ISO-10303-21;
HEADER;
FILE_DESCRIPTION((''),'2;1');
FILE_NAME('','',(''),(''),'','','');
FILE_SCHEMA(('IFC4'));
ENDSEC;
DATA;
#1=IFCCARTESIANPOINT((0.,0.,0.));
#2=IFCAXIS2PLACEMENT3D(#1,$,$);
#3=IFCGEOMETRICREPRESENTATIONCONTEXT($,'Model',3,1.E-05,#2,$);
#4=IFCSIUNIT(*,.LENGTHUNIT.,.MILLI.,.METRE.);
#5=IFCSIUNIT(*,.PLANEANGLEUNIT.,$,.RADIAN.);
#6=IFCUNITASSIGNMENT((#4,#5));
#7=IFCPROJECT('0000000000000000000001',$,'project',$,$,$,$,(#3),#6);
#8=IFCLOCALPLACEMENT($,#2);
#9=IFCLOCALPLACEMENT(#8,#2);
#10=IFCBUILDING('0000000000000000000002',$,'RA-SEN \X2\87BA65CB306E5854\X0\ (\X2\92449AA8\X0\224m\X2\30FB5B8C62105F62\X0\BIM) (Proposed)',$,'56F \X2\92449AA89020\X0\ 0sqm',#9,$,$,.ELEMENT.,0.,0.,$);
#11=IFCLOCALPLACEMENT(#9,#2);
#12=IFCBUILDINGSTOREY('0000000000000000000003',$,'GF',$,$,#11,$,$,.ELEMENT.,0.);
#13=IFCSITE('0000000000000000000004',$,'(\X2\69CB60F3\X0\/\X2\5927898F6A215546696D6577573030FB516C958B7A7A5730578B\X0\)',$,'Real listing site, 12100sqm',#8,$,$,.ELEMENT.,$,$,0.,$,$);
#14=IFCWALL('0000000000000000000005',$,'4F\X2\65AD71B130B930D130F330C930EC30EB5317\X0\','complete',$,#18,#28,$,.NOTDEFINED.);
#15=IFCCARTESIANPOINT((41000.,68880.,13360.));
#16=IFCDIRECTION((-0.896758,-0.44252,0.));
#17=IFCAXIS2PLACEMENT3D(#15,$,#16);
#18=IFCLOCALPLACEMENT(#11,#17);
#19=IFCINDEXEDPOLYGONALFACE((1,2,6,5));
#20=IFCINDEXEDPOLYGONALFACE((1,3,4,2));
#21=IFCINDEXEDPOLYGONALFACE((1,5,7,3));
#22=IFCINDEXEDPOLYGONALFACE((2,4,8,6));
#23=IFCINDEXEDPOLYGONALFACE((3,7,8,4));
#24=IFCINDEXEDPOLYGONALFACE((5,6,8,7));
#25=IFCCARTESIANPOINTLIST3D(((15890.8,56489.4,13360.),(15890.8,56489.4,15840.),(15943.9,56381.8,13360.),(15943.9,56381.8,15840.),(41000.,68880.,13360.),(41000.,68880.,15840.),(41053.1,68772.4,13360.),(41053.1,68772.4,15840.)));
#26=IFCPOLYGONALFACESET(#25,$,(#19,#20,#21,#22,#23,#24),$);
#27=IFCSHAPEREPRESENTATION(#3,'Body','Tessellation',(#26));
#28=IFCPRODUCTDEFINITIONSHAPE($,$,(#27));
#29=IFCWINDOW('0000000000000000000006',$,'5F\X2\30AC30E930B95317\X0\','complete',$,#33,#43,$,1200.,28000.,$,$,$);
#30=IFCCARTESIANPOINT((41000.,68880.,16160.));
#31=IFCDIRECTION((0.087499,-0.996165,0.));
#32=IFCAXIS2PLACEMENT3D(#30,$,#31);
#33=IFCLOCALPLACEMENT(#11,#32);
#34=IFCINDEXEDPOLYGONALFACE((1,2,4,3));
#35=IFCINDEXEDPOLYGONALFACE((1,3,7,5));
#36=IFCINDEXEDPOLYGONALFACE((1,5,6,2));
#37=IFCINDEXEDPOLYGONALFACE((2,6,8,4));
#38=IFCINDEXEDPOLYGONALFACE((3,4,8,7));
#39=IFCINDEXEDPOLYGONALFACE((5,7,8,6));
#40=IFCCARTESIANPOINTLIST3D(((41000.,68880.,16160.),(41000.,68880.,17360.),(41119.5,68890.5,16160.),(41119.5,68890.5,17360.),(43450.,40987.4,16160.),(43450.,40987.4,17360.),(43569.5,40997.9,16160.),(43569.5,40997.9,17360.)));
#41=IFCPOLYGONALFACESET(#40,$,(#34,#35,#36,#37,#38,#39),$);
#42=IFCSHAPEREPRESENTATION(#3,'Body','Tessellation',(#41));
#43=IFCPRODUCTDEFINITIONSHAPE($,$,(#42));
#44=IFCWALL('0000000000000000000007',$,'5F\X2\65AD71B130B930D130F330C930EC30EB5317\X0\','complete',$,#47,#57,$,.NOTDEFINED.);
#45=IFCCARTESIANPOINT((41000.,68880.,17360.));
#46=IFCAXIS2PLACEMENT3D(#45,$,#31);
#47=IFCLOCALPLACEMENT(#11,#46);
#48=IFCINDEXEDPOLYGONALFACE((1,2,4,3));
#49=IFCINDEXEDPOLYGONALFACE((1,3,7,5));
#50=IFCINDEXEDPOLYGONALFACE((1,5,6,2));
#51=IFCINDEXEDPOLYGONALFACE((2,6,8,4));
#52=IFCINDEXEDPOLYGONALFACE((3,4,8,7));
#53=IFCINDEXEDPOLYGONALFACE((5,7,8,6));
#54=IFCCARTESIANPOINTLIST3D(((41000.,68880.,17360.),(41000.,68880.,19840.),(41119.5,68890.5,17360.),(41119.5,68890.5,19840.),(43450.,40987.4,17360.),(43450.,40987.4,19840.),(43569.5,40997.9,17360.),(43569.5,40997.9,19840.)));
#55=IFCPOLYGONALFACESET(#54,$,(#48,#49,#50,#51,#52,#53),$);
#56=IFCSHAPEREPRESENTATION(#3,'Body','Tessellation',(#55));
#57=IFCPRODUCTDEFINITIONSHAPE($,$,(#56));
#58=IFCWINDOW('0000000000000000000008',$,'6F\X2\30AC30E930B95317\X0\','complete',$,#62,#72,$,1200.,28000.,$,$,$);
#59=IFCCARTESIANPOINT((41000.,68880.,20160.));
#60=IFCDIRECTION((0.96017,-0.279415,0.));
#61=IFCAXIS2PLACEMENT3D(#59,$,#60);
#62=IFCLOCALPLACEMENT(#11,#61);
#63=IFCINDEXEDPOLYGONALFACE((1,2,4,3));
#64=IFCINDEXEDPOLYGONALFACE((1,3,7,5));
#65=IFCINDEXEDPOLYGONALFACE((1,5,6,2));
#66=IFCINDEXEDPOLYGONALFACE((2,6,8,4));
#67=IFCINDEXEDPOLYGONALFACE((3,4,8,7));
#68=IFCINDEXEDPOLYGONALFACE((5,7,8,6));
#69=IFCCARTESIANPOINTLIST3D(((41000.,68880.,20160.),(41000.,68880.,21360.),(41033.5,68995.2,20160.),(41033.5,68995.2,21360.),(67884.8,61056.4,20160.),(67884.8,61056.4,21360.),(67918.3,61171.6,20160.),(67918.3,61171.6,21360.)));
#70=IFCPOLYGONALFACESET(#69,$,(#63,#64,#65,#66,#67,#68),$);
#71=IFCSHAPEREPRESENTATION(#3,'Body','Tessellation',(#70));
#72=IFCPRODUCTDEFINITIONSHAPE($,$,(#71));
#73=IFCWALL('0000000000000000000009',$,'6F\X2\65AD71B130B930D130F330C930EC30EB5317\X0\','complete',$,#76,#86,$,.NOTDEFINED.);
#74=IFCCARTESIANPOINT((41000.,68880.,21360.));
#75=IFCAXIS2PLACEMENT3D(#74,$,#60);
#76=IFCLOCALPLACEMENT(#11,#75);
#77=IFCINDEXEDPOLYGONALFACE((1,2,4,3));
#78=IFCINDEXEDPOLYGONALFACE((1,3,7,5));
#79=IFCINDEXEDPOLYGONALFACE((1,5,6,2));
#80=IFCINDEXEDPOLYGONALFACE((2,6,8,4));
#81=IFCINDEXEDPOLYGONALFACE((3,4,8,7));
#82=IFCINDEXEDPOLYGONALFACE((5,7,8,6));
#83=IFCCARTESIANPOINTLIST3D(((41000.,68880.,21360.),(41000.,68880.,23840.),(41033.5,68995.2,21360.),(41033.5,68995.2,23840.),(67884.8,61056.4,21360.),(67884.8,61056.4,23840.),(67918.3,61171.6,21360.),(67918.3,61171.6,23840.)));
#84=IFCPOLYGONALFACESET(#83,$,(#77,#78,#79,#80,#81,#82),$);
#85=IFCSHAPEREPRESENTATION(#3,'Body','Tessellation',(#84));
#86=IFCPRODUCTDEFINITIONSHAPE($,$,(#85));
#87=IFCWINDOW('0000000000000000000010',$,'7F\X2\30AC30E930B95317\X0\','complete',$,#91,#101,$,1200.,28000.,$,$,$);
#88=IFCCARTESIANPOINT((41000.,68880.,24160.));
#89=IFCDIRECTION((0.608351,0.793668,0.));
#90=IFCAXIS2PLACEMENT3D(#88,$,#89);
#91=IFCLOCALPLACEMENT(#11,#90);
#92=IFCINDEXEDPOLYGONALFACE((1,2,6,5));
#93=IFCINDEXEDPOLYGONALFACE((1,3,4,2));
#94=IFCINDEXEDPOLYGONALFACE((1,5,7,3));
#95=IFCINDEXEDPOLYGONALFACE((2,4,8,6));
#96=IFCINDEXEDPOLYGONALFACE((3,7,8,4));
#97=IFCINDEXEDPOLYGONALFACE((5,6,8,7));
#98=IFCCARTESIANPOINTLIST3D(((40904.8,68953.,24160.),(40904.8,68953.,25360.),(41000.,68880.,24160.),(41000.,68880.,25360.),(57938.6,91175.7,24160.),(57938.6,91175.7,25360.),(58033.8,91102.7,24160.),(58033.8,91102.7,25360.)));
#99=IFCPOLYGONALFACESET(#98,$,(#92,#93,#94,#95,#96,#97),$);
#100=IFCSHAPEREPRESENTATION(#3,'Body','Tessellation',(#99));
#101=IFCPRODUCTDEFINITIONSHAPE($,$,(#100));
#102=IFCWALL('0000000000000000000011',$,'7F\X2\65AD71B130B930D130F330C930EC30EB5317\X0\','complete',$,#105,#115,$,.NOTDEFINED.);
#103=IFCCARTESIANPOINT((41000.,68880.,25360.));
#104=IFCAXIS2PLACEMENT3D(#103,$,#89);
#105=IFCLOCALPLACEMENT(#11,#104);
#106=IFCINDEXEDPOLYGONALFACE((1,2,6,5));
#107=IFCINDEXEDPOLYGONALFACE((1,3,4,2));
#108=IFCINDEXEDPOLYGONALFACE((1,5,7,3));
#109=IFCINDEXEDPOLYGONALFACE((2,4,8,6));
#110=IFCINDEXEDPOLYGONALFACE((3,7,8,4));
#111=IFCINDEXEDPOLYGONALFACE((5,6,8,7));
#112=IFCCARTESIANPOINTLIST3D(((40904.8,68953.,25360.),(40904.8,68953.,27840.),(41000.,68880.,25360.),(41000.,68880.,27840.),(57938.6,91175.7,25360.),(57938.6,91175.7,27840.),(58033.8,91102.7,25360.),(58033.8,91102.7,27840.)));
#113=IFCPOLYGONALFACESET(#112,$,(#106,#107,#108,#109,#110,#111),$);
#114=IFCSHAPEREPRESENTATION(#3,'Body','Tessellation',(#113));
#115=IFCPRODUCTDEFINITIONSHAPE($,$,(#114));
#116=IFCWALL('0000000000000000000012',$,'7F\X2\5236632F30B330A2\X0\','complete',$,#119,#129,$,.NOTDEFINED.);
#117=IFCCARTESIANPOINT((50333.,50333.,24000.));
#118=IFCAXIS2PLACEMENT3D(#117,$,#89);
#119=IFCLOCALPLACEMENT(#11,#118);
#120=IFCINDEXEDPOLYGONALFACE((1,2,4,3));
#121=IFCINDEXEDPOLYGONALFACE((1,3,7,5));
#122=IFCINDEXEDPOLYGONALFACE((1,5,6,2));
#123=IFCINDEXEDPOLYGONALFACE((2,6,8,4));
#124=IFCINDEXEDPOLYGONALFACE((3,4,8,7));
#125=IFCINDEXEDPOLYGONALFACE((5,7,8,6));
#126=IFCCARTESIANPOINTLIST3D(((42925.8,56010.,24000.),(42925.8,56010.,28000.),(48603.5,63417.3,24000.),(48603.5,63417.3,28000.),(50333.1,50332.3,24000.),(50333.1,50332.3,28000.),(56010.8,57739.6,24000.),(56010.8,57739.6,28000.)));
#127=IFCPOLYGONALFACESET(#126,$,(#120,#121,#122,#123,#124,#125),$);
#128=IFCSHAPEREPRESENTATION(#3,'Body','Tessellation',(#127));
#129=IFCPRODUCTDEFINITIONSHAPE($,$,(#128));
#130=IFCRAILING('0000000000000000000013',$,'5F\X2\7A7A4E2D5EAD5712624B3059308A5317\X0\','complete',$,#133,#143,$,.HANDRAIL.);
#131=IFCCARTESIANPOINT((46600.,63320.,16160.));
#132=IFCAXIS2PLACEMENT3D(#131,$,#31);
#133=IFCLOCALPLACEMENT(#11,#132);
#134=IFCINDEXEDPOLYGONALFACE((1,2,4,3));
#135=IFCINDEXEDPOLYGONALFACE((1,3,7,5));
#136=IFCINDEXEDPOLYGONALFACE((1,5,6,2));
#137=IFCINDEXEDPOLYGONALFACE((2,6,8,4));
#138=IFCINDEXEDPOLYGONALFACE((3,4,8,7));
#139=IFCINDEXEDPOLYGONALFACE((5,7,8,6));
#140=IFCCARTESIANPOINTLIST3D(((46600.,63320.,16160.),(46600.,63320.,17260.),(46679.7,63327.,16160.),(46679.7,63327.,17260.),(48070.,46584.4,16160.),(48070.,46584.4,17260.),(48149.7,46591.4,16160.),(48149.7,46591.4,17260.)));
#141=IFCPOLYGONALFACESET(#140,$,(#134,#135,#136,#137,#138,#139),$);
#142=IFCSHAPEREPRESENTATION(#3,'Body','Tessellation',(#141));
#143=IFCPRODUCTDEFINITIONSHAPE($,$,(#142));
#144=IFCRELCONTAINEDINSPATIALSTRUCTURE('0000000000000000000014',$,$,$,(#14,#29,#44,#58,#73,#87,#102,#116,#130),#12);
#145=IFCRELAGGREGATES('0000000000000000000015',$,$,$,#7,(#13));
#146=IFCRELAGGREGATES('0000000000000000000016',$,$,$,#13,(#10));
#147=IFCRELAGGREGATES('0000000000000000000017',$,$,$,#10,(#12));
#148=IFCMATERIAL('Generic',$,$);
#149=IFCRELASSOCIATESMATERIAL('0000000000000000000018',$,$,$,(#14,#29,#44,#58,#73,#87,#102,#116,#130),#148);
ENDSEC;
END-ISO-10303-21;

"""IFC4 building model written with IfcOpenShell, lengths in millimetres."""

from ifc_helpers import new_model, si_unit, frame, frame_2d, origin, place, context, project, spatial, rectangle, extrude, material, element, save


model = new_model("IFC4")

# Units and contexts
model_context = context("Model", 3, precision=1e-05, world=origin())
ifc_project = project(units=[si_unit("LENGTHUNIT", "METRE", prefix="MILLI"), si_unit("PLANEANGLEUNIT", "RADIAN")], contexts=[model_context])

# Site, building, storey
site_placement = place(None, origin())
site = spatial("IfcSite", under=ifc_project, at=site_placement, Name="(構想/大規模商業敷地・公開空地型)", ObjectType="Real listing site, 12100sqm", CompositionType="ELEMENT", RefElevation=0.0)
building_placement = place(site_placement, origin())
building = spatial("IfcBuilding", under=site, at=building_placement, Name="RA-SEN 螺旋の塔 (鉄骨224m・完成形BIM) (Proposed)", ObjectType="56F 鉄骨造 0sqm", CompositionType="ELEMENT", ElevationOfRefHeight=0.0, ElevationOfTerrain=0.0)
storey_placement = place(building_placement, origin())
storey = spatial("IfcBuildingStorey", under=building, at=storey_placement, Name="GF", CompositionType="ELEMENT", Elevation=0.0)

# Shared definitions
ifc_material = material(Name="Generic")

# Wall
wall_1_placement = place(storey_placement, frame((41000.0, 68880.0, 13360.0), x_axis=(-0.896758, -0.44252, 0.0)))
element("IfcWall", 1, at=wall_1_placement, inside=storey, material=ifc_material, Name="4F断熱スパンドレル北", Description="complete", PredefinedType="NOTDEFINED", context=model_context, shape_type="SweptSolid", body=[
    extrude(rectangle(XDim=28000.0, YDim=120.0, at=frame_2d((14000.0, 60.0))), frame((41000.0, 68880.0, 13360.0), x_axis=(-0.896758, -0.44252, 0.0)), (0.0, 0.0, 1.0), 2480.0),
])

# Window
window_1_placement = place(storey_placement, frame((41000.0, 68880.0, 16160.0), x_axis=(0.087499, -0.996165, 0.0)))
element("IfcWindow", 2, at=window_1_placement, inside=storey, material=ifc_material, Name="5Fガラス北", Description="complete", OverallHeight=1200.0, OverallWidth=28000.0, context=model_context, shape_type="SweptSolid", body=[
    extrude(rectangle(XDim=28000.0, YDim=120.0, at=frame_2d((14000.0, 60.0))), frame((41000.0, 68880.0, 16160.0), x_axis=(0.087499, -0.996165, 0.0)), (0.0, 0.0, 1.0), 1200.0),
])

# Wall
wall_2_placement = place(storey_placement, frame((41000.0, 68880.0, 17360.0), x_axis=(0.087499, -0.996165, 0.0)))
element("IfcWall", 3, at=wall_2_placement, inside=storey, material=ifc_material, Name="5F断熱スパンドレル北", Description="complete", PredefinedType="NOTDEFINED", context=model_context, shape_type="SweptSolid", body=[
    extrude(rectangle(XDim=28000.0, YDim=120.0, at=frame_2d((14000.0, 60.0))), frame((41000.0, 68880.0, 17360.0), x_axis=(0.087499, -0.996165, 0.0)), (0.0, 0.0, 1.0), 2480.0),
])

# Window
window_2_placement = place(storey_placement, frame((41000.0, 68880.0, 20160.0), x_axis=(0.96017, -0.279415, 0.0)))
element("IfcWindow", 4, at=window_2_placement, inside=storey, material=ifc_material, Name="6Fガラス北", Description="complete", OverallHeight=1200.0, OverallWidth=28000.0, context=model_context, shape_type="SweptSolid", body=[
    extrude(rectangle(XDim=28000.0, YDim=120.0, at=frame_2d((14000.0, 60.0))), frame((41000.0, 68880.0, 20160.0), x_axis=(0.96017, -0.279415, 0.0)), (0.0, 0.0, 1.0), 1200.0),
])

# Wall
wall_3_placement = place(storey_placement, frame((41000.0, 68880.0, 21360.0), x_axis=(0.96017, -0.279415, 0.0)))
element("IfcWall", 5, at=wall_3_placement, inside=storey, material=ifc_material, Name="6F断熱スパンドレル北", Description="complete", PredefinedType="NOTDEFINED", context=model_context, shape_type="SweptSolid", body=[
    extrude(rectangle(XDim=28000.0, YDim=120.0, at=frame_2d((14000.0, 60.0))), frame((41000.0, 68880.0, 21360.0), x_axis=(0.96017, -0.279415, 0.0)), (0.0, 0.0, 1.0), 2480.0),
])

# Window
window_3_placement = place(storey_placement, frame((41000.0, 68880.0, 24160.0), x_axis=(0.608351, 0.793668, 0.0)))
element("IfcWindow", 6, at=window_3_placement, inside=storey, material=ifc_material, Name="7Fガラス北", Description="complete", OverallHeight=1200.0, OverallWidth=28000.0, context=model_context, shape_type="SweptSolid", body=[
    extrude(rectangle(XDim=28000.0, YDim=120.0, at=frame_2d((14000.0, 60.0))), frame((41000.0, 68880.0, 24160.0), x_axis=(0.608351, 0.793668, 0.0)), (0.0, 0.0, 1.0), 1200.0),
])

# Walls
wall_4_placement = place(storey_placement, frame((41000.0, 68880.0, 25360.0), x_axis=(0.608351, 0.793668, 0.0)))
element("IfcWall", 7, at=wall_4_placement, inside=storey, material=ifc_material, Name="7F断熱スパンドレル北", Description="complete", PredefinedType="NOTDEFINED", context=model_context, shape_type="SweptSolid", body=[
    extrude(rectangle(XDim=28000.0, YDim=120.0, at=frame_2d((14000.0, 60.0))), frame((41000.0, 68880.0, 25360.0), x_axis=(0.608351, 0.793668, 0.0)), (0.0, 0.0, 1.0), 2480.0),
])
wall_5_placement = place(storey_placement, frame((50333.0, 50333.0, 24000.0), x_axis=(0.608351, 0.793668, 0.0)))
element("IfcWall", 8, at=wall_5_placement, inside=storey, material=ifc_material, Name="7F制振コア", Description="complete", PredefinedType="NOTDEFINED", context=model_context, shape_type="SweptSolid", body=[
    extrude(rectangle(XDim=9333.0, YDim=9333.0, at=frame_2d((4666.0, 4666.0))), frame((50333.0, 50333.0, 24000.0), x_axis=(0.608351, 0.793668, 0.0)), (0.0, 0.0, 1.0), 4000.0),
])

# Railing
railing_placement = place(storey_placement, frame((46600.0, 63320.0, 16160.0), x_axis=(0.087499, -0.996165, 0.0)))
element("IfcRailing", 9, at=railing_placement, inside=storey, material=ifc_material, Name="5F空中庭園手すり北", Description="complete", PredefinedType="HANDRAIL", context=model_context, shape_type="SweptSolid", body=[
    extrude(rectangle(XDim=16800.0, YDim=80.0, at=frame_2d((8400.0, 40.0))), frame((46600.0, 63320.0, 16160.0), x_axis=(0.087499, -0.996165, 0.0)), (0.0, 0.0, 1.0), 1100.0),
])

save(model, "model.ifc")
